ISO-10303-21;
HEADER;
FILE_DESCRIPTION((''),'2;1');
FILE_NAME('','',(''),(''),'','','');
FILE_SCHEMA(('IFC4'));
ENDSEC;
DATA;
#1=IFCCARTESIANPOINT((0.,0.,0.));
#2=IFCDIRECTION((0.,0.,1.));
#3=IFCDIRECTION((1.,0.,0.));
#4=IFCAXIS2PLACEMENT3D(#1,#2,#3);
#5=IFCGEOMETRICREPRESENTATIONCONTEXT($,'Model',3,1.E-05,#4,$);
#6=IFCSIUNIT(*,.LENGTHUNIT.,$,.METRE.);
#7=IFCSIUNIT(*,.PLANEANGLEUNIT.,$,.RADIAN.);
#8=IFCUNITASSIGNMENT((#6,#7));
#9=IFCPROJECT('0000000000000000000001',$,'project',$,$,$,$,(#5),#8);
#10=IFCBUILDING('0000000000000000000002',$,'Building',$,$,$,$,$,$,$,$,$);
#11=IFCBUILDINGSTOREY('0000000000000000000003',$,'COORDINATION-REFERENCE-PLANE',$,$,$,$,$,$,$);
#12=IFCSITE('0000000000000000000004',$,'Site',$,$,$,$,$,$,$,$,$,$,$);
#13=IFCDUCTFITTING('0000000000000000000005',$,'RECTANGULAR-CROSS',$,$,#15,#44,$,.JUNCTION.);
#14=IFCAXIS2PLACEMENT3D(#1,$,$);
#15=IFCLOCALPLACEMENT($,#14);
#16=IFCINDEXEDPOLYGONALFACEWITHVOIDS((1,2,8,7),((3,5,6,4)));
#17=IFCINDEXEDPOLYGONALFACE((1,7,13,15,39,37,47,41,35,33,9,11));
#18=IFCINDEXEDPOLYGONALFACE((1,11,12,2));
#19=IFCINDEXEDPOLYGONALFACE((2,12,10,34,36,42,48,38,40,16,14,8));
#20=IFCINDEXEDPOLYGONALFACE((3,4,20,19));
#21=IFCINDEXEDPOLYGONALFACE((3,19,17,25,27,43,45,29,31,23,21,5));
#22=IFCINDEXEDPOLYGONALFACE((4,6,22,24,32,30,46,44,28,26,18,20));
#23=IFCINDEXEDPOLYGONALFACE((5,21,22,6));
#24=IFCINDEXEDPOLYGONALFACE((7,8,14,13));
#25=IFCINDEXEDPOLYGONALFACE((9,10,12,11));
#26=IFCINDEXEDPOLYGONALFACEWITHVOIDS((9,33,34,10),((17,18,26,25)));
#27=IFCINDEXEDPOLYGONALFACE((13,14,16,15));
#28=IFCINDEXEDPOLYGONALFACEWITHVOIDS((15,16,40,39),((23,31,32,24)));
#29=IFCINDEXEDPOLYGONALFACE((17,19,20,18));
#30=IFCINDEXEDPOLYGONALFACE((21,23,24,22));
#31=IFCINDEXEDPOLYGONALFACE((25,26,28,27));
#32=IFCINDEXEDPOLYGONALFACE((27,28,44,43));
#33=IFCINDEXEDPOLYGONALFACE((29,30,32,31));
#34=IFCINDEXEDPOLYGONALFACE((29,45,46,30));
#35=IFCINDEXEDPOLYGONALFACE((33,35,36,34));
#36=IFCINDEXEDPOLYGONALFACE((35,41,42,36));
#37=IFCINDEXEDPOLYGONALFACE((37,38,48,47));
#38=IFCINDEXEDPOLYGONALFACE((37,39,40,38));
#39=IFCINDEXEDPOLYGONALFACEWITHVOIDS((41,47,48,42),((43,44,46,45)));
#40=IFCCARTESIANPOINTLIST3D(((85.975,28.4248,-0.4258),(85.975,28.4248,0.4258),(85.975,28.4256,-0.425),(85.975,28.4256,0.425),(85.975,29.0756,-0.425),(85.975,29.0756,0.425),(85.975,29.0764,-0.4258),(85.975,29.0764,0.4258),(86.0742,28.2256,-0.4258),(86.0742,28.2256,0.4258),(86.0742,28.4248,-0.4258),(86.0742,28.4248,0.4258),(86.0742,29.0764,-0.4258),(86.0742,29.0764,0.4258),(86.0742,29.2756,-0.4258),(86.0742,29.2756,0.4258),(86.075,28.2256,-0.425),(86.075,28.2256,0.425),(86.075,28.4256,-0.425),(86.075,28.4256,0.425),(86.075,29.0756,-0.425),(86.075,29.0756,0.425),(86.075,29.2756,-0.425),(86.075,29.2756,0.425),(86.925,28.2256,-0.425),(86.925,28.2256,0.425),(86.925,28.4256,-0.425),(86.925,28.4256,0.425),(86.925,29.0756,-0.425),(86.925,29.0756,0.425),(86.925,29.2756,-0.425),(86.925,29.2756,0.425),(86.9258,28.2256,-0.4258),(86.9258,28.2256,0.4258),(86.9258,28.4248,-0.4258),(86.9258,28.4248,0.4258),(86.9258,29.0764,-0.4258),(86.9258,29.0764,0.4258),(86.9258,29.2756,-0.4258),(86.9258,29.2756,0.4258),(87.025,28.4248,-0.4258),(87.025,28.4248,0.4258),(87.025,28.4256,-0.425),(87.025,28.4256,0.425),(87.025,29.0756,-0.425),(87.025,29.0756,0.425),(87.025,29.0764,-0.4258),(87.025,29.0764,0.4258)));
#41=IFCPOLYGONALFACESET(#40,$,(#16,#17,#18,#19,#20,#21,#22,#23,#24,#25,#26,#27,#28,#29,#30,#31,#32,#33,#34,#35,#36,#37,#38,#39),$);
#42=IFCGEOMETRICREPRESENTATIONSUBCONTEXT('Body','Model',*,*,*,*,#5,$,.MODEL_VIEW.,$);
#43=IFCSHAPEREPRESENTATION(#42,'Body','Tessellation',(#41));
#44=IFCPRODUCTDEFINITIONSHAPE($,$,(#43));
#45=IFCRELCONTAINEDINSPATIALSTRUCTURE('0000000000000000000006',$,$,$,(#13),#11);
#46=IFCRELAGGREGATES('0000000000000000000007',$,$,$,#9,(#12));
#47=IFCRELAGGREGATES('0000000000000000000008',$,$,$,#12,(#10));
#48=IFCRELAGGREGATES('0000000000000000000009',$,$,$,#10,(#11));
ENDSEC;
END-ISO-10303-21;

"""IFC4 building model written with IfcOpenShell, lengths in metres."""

from ifc_helpers import new_model, si_unit, frame, origin_with_axes, place, context, subcontext, project, spatial, rectangle, extrude, boolean, element, save


model = new_model("IFC4")

# Units and contexts
model_context = context("Model", 3, precision=1e-05, world=origin_with_axes())
body_context_1 = subcontext(model_context, "Body", "Model", "MODEL_VIEW")
ifc_project = project(units=[si_unit("LENGTHUNIT", "METRE"), si_unit("PLANEANGLEUNIT", "RADIAN")], contexts=[model_context])

# Site, building, storey
site = spatial("IfcSite", under=ifc_project, Name="Site")
building = spatial("IfcBuilding", under=site, Name="Building")
storey = spatial("IfcBuildingStorey", under=building, Name="COORDINATION-REFERENCE-PLANE")

# Duct fitting
duct_fitting_1_placement = place(None, frame((86.5, 28.7506, 0.0), z_axis=(0.0, -1.0, 0.0), x_axis=(1.0, 0.0, 0.0)))
solid = boolean("UNION", extrude(rectangle(XDim=0.85, YDim=0.85), frame((0.0, 0.0, -0.525), z_axis=(0.0, 0.0, 1.0), x_axis=(1.0, 0.0, 0.0)), (0.0, 0.0, 1.0), 1.05), extrude(rectangle(XDim=0.65, YDim=0.85), frame((-0.525, 0.0, 0.0), z_axis=(1.0, 0.0, 0.0), x_axis=(0.0, 0.0, -1.0)), (0.0, 0.0, 1.0), 1.05))
element("IfcDuctFitting", 1, at=duct_fitting_1_placement, inside=storey, Name="RECTANGULAR-CROSS", PredefinedType="JUNCTION", context=body_context_1, shape_type="CSG", body=[
    boolean("DIFFERENCE", boolean("UNION", extrude(rectangle(XDim=0.8516, YDim=0.8516), frame((0.0, 0.0, -0.525), z_axis=(0.0, 0.0, 1.0), x_axis=(1.0, 0.0, 0.0)), (0.0, 0.0, 1.0), 1.05), extrude(rectangle(XDim=0.6516, YDim=0.8516), frame((-0.525, 0.0, 0.0), z_axis=(1.0, 0.0, 0.0), x_axis=(0.0, 0.0, -1.0)), (0.0, 0.0, 1.0), 1.05)), solid),
])

save(model, "model.ifc")
